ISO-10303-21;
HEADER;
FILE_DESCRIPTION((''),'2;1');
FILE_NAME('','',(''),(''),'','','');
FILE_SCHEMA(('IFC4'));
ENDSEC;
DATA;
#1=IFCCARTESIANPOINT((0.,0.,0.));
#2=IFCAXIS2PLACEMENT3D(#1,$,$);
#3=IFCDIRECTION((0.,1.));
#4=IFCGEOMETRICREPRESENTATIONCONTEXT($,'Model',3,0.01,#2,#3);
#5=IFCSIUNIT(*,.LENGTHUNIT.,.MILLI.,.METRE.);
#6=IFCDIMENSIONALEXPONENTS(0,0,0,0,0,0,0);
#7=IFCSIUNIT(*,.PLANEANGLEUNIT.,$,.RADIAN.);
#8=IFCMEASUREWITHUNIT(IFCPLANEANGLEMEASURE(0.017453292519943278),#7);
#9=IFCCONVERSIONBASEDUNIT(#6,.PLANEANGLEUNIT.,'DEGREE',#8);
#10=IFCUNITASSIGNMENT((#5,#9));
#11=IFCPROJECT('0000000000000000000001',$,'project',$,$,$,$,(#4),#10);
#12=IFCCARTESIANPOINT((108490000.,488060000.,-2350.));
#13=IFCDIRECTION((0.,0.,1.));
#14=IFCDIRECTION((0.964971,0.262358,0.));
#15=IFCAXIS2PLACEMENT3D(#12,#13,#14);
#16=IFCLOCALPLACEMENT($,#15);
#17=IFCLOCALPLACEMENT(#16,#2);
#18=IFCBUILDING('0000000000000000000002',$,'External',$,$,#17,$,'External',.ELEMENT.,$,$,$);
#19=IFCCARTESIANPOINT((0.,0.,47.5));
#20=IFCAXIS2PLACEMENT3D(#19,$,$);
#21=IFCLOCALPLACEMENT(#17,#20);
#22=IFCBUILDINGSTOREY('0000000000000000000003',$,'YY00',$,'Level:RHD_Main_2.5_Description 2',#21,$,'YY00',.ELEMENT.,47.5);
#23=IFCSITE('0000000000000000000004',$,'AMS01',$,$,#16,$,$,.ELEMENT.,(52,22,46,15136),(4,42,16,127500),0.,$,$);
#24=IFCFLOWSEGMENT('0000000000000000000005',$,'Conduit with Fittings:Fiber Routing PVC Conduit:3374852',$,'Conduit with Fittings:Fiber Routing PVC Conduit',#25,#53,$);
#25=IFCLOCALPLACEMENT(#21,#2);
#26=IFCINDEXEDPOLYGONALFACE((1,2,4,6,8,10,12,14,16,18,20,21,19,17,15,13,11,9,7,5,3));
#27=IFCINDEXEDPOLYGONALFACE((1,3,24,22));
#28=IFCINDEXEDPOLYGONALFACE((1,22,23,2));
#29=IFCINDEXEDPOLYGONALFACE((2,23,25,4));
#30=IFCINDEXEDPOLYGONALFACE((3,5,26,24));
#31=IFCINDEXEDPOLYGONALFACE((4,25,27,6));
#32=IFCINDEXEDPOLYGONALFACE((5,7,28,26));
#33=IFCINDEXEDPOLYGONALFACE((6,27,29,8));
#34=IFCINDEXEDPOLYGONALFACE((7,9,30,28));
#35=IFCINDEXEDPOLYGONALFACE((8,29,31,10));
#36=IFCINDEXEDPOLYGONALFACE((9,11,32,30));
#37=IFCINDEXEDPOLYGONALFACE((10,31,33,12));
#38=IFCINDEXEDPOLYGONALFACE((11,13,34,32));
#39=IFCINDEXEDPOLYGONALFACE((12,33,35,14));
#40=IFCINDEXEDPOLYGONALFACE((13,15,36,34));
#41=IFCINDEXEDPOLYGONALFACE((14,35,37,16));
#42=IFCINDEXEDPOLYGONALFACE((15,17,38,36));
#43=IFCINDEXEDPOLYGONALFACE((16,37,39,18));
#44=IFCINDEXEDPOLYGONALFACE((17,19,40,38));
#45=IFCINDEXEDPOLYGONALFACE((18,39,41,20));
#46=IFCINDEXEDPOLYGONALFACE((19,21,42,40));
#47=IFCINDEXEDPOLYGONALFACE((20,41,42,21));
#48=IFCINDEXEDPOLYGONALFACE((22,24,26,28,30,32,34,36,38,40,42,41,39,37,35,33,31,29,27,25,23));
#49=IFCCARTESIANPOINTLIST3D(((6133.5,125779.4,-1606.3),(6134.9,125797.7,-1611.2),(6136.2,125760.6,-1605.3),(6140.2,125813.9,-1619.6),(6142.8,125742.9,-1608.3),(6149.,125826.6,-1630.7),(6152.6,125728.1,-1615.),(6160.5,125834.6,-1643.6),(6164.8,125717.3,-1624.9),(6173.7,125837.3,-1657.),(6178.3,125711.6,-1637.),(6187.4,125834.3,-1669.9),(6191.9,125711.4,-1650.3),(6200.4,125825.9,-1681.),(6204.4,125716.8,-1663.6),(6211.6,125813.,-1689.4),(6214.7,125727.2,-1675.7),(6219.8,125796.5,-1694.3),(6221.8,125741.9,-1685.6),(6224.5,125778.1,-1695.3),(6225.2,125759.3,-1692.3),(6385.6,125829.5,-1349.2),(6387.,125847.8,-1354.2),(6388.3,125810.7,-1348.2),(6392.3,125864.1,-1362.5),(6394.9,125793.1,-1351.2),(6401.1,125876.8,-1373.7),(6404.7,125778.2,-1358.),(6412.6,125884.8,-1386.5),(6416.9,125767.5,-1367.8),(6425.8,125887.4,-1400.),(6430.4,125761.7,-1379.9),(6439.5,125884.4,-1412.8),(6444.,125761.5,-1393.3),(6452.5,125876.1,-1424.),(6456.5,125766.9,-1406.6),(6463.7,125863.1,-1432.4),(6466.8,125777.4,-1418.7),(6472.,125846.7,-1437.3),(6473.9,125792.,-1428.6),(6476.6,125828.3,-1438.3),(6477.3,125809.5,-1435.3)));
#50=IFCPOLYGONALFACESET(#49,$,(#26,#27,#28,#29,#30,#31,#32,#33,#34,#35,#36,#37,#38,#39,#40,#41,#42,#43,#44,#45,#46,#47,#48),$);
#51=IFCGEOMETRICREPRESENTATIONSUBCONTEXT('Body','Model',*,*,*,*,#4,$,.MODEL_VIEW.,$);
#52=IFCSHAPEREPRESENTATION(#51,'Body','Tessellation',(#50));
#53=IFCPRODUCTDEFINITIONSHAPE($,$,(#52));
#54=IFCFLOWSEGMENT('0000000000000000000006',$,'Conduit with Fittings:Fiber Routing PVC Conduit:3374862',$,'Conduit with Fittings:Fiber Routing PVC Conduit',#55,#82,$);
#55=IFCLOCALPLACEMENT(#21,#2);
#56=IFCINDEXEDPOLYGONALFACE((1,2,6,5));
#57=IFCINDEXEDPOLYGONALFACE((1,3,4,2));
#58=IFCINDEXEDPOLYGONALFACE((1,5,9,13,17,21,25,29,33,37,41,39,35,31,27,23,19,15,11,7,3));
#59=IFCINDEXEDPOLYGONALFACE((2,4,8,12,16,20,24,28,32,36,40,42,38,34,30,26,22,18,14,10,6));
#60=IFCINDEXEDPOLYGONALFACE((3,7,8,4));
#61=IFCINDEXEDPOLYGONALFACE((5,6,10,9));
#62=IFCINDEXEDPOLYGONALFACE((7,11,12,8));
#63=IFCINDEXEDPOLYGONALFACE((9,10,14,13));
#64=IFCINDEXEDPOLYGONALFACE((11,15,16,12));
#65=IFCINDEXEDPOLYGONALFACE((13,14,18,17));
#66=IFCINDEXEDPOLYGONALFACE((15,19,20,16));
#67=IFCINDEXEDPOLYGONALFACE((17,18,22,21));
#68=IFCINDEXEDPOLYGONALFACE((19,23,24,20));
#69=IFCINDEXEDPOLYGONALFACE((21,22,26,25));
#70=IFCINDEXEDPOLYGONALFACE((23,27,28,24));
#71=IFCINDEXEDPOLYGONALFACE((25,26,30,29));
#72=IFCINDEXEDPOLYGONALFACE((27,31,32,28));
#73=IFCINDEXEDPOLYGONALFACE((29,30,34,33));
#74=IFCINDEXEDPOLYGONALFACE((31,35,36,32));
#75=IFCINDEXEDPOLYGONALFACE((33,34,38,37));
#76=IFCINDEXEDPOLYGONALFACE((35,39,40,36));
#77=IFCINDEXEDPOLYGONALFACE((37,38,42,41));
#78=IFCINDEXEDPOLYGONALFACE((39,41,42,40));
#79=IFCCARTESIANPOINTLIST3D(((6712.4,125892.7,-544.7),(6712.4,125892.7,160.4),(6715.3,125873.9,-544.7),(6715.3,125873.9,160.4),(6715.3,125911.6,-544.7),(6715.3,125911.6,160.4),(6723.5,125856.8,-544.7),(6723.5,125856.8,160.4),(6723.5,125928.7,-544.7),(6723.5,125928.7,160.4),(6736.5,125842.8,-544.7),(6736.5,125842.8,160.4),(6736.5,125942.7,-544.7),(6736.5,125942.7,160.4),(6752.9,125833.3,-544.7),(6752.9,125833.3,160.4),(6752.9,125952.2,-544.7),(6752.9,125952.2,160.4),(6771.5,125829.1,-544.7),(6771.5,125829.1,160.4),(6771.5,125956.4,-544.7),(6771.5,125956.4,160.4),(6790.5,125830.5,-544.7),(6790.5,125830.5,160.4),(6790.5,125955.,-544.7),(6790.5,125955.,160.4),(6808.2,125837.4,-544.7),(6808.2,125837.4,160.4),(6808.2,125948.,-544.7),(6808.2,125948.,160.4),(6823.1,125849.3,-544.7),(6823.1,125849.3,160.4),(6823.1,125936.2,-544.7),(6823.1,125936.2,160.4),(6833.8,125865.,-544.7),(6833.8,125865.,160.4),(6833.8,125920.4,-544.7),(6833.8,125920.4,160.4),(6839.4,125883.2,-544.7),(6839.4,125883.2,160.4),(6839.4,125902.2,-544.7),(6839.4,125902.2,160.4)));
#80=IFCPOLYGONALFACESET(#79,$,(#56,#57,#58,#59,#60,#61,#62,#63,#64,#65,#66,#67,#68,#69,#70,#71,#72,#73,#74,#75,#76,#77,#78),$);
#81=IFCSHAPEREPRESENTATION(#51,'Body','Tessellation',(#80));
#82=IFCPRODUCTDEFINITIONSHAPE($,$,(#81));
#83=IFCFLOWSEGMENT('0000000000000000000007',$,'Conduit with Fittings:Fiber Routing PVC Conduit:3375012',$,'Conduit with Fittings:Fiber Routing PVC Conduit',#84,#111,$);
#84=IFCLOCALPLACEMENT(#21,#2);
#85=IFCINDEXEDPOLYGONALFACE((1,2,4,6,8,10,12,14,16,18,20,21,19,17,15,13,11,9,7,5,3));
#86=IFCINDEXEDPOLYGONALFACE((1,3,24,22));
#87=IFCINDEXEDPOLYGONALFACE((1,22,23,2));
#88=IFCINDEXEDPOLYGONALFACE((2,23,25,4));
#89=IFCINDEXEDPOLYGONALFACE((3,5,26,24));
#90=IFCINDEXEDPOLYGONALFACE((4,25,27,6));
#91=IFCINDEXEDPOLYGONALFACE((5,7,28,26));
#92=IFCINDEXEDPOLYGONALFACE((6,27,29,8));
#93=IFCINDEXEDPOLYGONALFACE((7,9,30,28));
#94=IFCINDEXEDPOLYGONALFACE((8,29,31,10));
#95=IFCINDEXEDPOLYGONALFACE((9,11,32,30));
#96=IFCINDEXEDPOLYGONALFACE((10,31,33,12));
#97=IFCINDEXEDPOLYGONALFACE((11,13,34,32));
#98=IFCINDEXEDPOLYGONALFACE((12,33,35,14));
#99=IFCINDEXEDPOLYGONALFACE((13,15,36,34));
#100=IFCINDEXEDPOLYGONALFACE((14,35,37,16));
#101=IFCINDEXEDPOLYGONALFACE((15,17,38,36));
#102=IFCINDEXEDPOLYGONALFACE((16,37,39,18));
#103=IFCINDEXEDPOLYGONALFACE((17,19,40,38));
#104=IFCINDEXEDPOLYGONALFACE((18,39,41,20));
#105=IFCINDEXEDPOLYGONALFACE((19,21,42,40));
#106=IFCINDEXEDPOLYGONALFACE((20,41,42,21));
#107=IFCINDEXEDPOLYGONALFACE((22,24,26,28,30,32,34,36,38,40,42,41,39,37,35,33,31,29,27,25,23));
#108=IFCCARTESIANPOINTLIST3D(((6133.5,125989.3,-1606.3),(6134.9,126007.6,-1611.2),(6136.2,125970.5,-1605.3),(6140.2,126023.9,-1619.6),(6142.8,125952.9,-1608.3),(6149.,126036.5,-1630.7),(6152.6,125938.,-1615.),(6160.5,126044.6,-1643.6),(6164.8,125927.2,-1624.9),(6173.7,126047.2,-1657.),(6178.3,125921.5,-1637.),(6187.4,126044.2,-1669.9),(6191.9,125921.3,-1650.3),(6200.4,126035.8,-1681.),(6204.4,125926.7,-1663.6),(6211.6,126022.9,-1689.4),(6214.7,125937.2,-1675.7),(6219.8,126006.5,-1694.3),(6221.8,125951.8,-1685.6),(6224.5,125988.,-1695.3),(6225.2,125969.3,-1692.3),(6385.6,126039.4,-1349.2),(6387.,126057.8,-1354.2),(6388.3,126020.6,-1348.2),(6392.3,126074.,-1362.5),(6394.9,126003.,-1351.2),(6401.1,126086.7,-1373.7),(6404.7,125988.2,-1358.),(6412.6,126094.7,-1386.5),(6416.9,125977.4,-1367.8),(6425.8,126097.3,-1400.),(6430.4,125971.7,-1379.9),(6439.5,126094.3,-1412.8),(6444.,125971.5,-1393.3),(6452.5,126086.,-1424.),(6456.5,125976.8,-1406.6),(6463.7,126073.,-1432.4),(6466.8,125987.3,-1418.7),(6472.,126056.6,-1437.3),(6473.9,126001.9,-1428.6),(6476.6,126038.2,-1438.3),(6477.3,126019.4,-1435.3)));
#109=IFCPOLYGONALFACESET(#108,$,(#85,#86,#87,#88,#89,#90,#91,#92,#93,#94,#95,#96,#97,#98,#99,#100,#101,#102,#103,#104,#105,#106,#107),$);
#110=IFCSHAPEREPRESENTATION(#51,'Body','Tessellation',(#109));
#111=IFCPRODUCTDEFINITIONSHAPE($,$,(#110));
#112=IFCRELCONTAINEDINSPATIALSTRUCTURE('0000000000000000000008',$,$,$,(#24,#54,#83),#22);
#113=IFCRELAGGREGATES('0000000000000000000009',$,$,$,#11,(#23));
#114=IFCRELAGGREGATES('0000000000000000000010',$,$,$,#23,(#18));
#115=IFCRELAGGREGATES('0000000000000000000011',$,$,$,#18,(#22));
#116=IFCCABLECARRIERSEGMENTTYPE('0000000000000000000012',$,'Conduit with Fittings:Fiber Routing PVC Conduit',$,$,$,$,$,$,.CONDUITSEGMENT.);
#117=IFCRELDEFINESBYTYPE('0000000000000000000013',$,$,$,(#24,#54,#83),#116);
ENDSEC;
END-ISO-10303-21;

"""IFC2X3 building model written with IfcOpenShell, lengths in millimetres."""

from ifc_helpers import new_model, entity, si_unit, converted_unit, direction, frame, frame_2d, origin, origin_2d_with_axis, place, context, subcontext, project, spatial, circle, extrude, type_object, element, save


model = new_model("IFC2X3")

# Units and contexts
model_context = context("Model", 3, precision=0.01, world=origin(), true_north=direction((0.0, 1.0)))
body_context = subcontext(model_context, "Body", "Model", "MODEL_VIEW")
ifc_project = project(units=[si_unit("LENGTHUNIT", "METRE", prefix="MILLI"), converted_unit("PLANEANGLEUNIT", "DEGREE", entity("IfcPlaneAngleMeasure", 0.017453292519943278), si_unit("PLANEANGLEUNIT", "RADIAN"), dimensions=[0, 0, 0, 0, 0, 0, 0])], contexts=[model_context])

# Site, building, storey
site_placement = place(None, frame((108490000.0, 488060000.0, -2350.0), z_axis=(0.0, 0.0, 1.0), x_axis=(0.964971, 0.262358, 0.0)))
site = spatial("IfcSite", under=ifc_project, at=site_placement, Name="AMS01", CompositionType="ELEMENT", RefLatitude=(52, 22, 46, 15136), RefLongitude=(4, 42, 16, 127500), RefElevation=0.0)
building_placement = place(site_placement, origin())
building = spatial("IfcBuilding", under=site, at=building_placement, Name="External", LongName="External", CompositionType="ELEMENT")
storey_placement = place(building_placement, frame((0.0, 0.0, 47.5)))
storey = spatial("IfcBuildingStorey", under=building, at=storey_placement, Name="YY00", ObjectType="Level:RHD_Main_2.5_Description 2", LongName="YY00", CompositionType="ELEMENT", Elevation=47.5)

# Flow segments
cable_carrier_segment_type = type_object("IfcCableCarrierSegmentType", Name="Conduit with Fittings:Fiber Routing PVC Conduit", PredefinedType="CONDUITSEGMENT")
flow_segment_1_placement = place(storey_placement, origin())
element("IfcFlowSegment", 1, at=flow_segment_1_placement, inside=storey, type_object=cable_carrier_segment_type, Name="Conduit with Fittings:Fiber Routing PVC Conduit:3374852", ObjectType="Conduit with Fittings:Fiber Routing PVC Conduit", context=body_context, shape_type="SweptSolid", body=[
    extrude(circle(Radius=63.9, at=frame_2d((0.0, 0.0), x_axis=(1.0, 0.0))), frame((6179.4, 125774.0, -1650.3), z_axis=(0.69352, 0.13795, 0.707107), x_axis=(0.19509, -0.980785, 0.0)), (0.0, 0.0, 1.0), 363.5),
])
flow_segment_2_placement = place(storey_placement, origin())
element("IfcFlowSegment", 2, at=flow_segment_2_placement, inside=storey, type_object=cable_carrier_segment_type, Name="Conduit with Fittings:Fiber Routing PVC Conduit:3374862", ObjectType="Conduit with Fittings:Fiber Routing PVC Conduit", context=body_context, shape_type="SweptSolid", body=[
    extrude(circle(Radius=63.9, at=origin_2d_with_axis()), frame((6776.3, 125892.7, -544.7), z_axis=(0.0, 0.0, 1.0), x_axis=(-1.0, 0.0, 0.0)), (0.0, 0.0, 1.0), 705.1),
])
flow_segment_3_placement = place(storey_placement, origin())
element("IfcFlowSegment", 3, at=flow_segment_3_placement, inside=storey, type_object=cable_carrier_segment_type, Name="Conduit with Fittings:Fiber Routing PVC Conduit:3375012", ObjectType="Conduit with Fittings:Fiber Routing PVC Conduit", context=body_context, shape_type="SweptSolid", body=[
    extrude(circle(Radius=63.9, at=frame_2d((0.0, 0.0), x_axis=(1.0, 0.0))), frame((6179.4, 125983.9, -1650.3), z_axis=(0.69352, 0.13795, 0.707107), x_axis=(0.19509, -0.980785, 0.0)), (0.0, 0.0, 1.0), 363.5),
])

save(model, "model.ifc")
